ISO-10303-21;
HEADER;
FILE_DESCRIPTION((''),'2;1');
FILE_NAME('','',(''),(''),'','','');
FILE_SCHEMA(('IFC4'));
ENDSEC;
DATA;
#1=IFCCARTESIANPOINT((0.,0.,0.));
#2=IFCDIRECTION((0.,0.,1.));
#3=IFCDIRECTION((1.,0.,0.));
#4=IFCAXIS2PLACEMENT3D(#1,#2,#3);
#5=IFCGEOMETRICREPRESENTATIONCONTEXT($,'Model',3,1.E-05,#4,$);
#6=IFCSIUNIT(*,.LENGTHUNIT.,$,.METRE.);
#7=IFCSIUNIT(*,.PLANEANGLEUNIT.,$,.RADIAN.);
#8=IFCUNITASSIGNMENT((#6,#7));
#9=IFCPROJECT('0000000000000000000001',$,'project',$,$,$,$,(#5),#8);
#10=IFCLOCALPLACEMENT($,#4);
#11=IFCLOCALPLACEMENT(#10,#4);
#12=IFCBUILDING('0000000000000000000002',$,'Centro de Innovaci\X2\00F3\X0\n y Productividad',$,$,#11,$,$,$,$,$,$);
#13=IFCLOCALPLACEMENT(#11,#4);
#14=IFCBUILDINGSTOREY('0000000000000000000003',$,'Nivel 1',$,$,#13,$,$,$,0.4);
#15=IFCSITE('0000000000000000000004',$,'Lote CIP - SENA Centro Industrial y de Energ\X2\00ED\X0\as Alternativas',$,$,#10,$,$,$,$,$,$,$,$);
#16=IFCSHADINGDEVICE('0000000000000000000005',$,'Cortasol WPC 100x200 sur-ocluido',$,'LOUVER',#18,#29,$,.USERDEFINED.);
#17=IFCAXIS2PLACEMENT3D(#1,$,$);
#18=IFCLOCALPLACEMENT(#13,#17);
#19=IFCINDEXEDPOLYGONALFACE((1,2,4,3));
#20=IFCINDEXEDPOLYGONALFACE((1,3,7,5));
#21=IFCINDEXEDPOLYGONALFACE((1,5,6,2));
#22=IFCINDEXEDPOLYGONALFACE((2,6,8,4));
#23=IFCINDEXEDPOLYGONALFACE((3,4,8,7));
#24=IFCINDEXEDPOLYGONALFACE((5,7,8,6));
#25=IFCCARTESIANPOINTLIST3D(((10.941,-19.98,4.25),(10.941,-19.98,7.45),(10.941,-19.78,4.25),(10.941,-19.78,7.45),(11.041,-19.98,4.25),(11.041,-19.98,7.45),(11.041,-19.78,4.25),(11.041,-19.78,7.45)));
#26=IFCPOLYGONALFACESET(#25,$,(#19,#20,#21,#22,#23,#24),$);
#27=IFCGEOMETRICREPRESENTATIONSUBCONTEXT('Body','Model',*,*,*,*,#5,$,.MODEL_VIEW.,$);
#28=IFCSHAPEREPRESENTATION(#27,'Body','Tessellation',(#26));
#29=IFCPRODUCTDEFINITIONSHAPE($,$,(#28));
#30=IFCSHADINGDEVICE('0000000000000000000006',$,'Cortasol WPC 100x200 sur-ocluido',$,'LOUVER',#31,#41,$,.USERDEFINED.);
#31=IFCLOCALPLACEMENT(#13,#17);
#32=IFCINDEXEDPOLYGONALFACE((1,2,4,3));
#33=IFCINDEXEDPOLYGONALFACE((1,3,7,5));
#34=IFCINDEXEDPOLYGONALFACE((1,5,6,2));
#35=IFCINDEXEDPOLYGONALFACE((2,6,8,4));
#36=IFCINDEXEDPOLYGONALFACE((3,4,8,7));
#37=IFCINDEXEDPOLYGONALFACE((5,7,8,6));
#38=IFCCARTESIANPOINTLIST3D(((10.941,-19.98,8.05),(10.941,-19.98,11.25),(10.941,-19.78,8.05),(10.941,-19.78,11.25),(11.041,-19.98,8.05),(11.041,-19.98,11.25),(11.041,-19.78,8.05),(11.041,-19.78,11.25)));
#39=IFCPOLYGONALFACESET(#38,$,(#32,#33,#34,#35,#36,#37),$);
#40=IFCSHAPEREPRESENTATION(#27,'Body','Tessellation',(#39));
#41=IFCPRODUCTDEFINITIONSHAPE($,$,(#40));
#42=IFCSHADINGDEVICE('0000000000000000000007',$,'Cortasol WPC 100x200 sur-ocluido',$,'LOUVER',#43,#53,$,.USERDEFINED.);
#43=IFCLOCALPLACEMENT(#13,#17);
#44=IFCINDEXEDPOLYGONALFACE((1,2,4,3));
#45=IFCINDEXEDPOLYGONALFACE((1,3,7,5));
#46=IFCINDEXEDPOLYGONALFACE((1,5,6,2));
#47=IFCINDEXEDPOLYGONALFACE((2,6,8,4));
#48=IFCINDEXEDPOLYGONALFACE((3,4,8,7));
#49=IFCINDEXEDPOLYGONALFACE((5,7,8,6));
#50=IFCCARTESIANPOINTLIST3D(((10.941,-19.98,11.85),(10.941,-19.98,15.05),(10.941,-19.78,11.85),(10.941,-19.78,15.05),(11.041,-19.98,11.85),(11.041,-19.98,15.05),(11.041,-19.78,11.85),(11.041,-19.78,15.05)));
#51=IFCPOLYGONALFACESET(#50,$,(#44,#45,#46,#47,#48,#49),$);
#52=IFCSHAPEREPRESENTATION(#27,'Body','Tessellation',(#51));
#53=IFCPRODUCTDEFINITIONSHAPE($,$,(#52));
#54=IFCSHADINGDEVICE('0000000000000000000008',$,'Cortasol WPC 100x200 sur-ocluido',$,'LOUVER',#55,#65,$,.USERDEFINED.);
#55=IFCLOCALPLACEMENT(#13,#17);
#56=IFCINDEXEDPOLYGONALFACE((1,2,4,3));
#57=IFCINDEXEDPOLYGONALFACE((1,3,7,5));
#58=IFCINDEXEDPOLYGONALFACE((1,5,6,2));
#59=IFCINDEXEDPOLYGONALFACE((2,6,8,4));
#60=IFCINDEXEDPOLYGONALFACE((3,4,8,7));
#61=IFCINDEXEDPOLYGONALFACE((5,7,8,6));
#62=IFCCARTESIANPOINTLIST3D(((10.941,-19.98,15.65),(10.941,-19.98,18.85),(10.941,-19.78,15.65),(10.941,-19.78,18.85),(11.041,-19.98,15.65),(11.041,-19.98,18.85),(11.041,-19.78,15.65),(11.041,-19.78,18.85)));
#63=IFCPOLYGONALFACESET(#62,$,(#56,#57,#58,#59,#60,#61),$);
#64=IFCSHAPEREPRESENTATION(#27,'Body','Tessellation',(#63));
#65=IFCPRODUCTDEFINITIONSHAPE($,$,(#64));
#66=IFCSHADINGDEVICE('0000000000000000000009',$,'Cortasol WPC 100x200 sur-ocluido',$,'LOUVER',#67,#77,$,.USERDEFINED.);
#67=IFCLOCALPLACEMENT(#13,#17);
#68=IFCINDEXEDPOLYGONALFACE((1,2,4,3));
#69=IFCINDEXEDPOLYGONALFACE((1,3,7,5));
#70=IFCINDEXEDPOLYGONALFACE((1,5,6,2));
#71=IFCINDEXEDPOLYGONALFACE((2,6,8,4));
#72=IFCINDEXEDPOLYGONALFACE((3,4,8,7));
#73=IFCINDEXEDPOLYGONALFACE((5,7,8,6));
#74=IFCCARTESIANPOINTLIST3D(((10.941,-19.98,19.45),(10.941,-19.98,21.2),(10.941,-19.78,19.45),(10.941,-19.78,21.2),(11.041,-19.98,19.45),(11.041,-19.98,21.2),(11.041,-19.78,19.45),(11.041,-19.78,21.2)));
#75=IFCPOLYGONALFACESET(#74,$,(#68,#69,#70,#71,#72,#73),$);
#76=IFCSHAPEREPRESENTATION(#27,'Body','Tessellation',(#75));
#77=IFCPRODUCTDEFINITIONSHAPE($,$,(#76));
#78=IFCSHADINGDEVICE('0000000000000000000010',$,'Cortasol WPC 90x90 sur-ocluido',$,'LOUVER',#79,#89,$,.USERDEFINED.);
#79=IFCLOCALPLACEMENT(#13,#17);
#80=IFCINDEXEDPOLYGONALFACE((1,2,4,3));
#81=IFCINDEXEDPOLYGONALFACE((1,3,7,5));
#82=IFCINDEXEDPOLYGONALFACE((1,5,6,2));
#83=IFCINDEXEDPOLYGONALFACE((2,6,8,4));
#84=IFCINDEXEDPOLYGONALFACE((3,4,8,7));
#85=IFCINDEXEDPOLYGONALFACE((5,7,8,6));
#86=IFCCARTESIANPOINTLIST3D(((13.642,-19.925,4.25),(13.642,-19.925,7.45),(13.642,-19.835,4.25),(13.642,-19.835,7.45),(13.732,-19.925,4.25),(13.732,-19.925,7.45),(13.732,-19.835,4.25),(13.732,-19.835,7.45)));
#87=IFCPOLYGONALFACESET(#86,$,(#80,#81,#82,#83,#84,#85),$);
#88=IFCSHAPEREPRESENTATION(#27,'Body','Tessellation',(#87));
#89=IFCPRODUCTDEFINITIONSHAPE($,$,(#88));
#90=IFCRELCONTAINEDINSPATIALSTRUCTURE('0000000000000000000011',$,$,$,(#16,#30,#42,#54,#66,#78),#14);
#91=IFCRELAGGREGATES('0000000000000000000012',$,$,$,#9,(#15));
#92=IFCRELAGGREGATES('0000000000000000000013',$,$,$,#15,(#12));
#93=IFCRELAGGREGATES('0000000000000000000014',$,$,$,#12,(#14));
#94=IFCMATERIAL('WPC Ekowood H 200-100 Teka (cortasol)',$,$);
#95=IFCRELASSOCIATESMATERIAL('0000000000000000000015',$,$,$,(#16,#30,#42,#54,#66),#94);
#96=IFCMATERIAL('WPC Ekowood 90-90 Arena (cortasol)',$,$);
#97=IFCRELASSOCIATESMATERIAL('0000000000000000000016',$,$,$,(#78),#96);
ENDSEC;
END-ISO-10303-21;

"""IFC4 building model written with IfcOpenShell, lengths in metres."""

from ifc_helpers import new_model, si_unit, frame, origin_with_axes, place, context, subcontext, project, spatial, polyline, outline, extrude, material, element, save


model = new_model("IFC4")

# Units and contexts
model_context = context("Model", 3, precision=1e-05, world=origin_with_axes())
body_context = subcontext(model_context, "Body", "Model", "MODEL_VIEW")
ifc_project = project(units=[si_unit("LENGTHUNIT", "METRE"), si_unit("PLANEANGLEUNIT", "RADIAN")], contexts=[model_context])

# Site, building, storey
site_placement = place(None, origin_with_axes())
site = spatial("IfcSite", under=ifc_project, at=site_placement, Name="Lote CIP - SENA Centro Industrial y de Energías Alternativas")
building_placement = place(site_placement, origin_with_axes())
building = spatial("IfcBuilding", under=site, at=building_placement, Name="Centro de Innovación y Productividad")
storey_placement = place(building_placement, origin_with_axes())
storey = spatial("IfcBuildingStorey", under=building, at=storey_placement, Name="Nivel 1", Elevation=0.4)

# Shading devices
ifc_material_1 = material(Name="WPC Ekowood 90-90 Arena (cortasol)")
ifc_material_2 = material(Name="WPC Ekowood H 200-100 Teka (cortasol)")
shading_device_1_placement = place(storey_placement, origin_with_axes())
element("IfcShadingDevice", 1, at=shading_device_1_placement, inside=storey, material=ifc_material_2, Name="Cortasol WPC 100x200 sur-ocluido", ObjectType="LOUVER", PredefinedType="USERDEFINED", context=body_context, shape_type="SweptSolid", body=[
    extrude(outline(polyline([(10.941, -19.98), (10.941, -19.78), (11.041, -19.78), (11.041, -19.98), (10.941, -19.98)])), frame((0.0, 0.0, 4.25)), (0.0, 0.0, 1.0), 3.2),
])
shading_device_2_placement = place(storey_placement, origin_with_axes())
element("IfcShadingDevice", 2, at=shading_device_2_placement, inside=storey, material=ifc_material_2, Name="Cortasol WPC 100x200 sur-ocluido", ObjectType="LOUVER", PredefinedType="USERDEFINED", context=body_context, shape_type="SweptSolid", body=[
    extrude(outline(polyline([(10.941, -19.98), (10.941, -19.78), (11.041, -19.78), (11.041, -19.98), (10.941, -19.98)])), frame((0.0, 0.0, 8.05)), (0.0, 0.0, 1.0), 3.2),
])
shading_device_3_placement = place(storey_placement, origin_with_axes())
element("IfcShadingDevice", 3, at=shading_device_3_placement, inside=storey, material=ifc_material_2, Name="Cortasol WPC 100x200 sur-ocluido", ObjectType="LOUVER", PredefinedType="USERDEFINED", context=body_context, shape_type="SweptSolid", body=[
    extrude(outline(polyline([(10.941, -19.98), (10.941, -19.78), (11.041, -19.78), (11.041, -19.98), (10.941, -19.98)])), frame((0.0, 0.0, 11.85)), (0.0, 0.0, 1.0), 3.2),
])
shading_device_4_placement = place(storey_placement, origin_with_axes())
element("IfcShadingDevice", 4, at=shading_device_4_placement, inside=storey, material=ifc_material_2, Name="Cortasol WPC 100x200 sur-ocluido", ObjectType="LOUVER", PredefinedType="USERDEFINED", context=body_context, shape_type="SweptSolid", body=[
    extrude(outline(polyline([(10.941, -19.98), (10.941, -19.78), (11.041, -19.78), (11.041, -19.98), (10.941, -19.98)])), frame((0.0, 0.0, 15.65)), (0.0, 0.0, 1.0), 3.2),
])
shading_device_5_placement = place(storey_placement, origin_with_axes())
element("IfcShadingDevice", 5, at=shading_device_5_placement, inside=storey, material=ifc_material_2, Name="Cortasol WPC 100x200 sur-ocluido", ObjectType="LOUVER", PredefinedType="USERDEFINED", context=body_context, shape_type="SweptSolid", body=[
    extrude(outline(polyline([(10.941, -19.98), (10.941, -19.78), (11.041, -19.78), (11.041, -19.98), (10.941, -19.98)])), frame((0.0, 0.0, 19.45)), (0.0, 0.0, 1.0), 1.75),
])
shading_device_6_placement = place(storey_placement, origin_with_axes())
element("IfcShadingDevice", 6, at=shading_device_6_placement, inside=storey, material=ifc_material_1, Name="Cortasol WPC 90x90 sur-ocluido", ObjectType="LOUVER", PredefinedType="USERDEFINED", context=body_context, shape_type="SweptSolid", body=[
    extrude(outline(polyline([(13.642, -19.925), (13.642, -19.835), (13.732, -19.835), (13.732, -19.925), (13.642, -19.925)])), frame((0.0, 0.0, 4.25)), (0.0, 0.0, 1.0), 3.2),
])

save(model, "model.ifc")
